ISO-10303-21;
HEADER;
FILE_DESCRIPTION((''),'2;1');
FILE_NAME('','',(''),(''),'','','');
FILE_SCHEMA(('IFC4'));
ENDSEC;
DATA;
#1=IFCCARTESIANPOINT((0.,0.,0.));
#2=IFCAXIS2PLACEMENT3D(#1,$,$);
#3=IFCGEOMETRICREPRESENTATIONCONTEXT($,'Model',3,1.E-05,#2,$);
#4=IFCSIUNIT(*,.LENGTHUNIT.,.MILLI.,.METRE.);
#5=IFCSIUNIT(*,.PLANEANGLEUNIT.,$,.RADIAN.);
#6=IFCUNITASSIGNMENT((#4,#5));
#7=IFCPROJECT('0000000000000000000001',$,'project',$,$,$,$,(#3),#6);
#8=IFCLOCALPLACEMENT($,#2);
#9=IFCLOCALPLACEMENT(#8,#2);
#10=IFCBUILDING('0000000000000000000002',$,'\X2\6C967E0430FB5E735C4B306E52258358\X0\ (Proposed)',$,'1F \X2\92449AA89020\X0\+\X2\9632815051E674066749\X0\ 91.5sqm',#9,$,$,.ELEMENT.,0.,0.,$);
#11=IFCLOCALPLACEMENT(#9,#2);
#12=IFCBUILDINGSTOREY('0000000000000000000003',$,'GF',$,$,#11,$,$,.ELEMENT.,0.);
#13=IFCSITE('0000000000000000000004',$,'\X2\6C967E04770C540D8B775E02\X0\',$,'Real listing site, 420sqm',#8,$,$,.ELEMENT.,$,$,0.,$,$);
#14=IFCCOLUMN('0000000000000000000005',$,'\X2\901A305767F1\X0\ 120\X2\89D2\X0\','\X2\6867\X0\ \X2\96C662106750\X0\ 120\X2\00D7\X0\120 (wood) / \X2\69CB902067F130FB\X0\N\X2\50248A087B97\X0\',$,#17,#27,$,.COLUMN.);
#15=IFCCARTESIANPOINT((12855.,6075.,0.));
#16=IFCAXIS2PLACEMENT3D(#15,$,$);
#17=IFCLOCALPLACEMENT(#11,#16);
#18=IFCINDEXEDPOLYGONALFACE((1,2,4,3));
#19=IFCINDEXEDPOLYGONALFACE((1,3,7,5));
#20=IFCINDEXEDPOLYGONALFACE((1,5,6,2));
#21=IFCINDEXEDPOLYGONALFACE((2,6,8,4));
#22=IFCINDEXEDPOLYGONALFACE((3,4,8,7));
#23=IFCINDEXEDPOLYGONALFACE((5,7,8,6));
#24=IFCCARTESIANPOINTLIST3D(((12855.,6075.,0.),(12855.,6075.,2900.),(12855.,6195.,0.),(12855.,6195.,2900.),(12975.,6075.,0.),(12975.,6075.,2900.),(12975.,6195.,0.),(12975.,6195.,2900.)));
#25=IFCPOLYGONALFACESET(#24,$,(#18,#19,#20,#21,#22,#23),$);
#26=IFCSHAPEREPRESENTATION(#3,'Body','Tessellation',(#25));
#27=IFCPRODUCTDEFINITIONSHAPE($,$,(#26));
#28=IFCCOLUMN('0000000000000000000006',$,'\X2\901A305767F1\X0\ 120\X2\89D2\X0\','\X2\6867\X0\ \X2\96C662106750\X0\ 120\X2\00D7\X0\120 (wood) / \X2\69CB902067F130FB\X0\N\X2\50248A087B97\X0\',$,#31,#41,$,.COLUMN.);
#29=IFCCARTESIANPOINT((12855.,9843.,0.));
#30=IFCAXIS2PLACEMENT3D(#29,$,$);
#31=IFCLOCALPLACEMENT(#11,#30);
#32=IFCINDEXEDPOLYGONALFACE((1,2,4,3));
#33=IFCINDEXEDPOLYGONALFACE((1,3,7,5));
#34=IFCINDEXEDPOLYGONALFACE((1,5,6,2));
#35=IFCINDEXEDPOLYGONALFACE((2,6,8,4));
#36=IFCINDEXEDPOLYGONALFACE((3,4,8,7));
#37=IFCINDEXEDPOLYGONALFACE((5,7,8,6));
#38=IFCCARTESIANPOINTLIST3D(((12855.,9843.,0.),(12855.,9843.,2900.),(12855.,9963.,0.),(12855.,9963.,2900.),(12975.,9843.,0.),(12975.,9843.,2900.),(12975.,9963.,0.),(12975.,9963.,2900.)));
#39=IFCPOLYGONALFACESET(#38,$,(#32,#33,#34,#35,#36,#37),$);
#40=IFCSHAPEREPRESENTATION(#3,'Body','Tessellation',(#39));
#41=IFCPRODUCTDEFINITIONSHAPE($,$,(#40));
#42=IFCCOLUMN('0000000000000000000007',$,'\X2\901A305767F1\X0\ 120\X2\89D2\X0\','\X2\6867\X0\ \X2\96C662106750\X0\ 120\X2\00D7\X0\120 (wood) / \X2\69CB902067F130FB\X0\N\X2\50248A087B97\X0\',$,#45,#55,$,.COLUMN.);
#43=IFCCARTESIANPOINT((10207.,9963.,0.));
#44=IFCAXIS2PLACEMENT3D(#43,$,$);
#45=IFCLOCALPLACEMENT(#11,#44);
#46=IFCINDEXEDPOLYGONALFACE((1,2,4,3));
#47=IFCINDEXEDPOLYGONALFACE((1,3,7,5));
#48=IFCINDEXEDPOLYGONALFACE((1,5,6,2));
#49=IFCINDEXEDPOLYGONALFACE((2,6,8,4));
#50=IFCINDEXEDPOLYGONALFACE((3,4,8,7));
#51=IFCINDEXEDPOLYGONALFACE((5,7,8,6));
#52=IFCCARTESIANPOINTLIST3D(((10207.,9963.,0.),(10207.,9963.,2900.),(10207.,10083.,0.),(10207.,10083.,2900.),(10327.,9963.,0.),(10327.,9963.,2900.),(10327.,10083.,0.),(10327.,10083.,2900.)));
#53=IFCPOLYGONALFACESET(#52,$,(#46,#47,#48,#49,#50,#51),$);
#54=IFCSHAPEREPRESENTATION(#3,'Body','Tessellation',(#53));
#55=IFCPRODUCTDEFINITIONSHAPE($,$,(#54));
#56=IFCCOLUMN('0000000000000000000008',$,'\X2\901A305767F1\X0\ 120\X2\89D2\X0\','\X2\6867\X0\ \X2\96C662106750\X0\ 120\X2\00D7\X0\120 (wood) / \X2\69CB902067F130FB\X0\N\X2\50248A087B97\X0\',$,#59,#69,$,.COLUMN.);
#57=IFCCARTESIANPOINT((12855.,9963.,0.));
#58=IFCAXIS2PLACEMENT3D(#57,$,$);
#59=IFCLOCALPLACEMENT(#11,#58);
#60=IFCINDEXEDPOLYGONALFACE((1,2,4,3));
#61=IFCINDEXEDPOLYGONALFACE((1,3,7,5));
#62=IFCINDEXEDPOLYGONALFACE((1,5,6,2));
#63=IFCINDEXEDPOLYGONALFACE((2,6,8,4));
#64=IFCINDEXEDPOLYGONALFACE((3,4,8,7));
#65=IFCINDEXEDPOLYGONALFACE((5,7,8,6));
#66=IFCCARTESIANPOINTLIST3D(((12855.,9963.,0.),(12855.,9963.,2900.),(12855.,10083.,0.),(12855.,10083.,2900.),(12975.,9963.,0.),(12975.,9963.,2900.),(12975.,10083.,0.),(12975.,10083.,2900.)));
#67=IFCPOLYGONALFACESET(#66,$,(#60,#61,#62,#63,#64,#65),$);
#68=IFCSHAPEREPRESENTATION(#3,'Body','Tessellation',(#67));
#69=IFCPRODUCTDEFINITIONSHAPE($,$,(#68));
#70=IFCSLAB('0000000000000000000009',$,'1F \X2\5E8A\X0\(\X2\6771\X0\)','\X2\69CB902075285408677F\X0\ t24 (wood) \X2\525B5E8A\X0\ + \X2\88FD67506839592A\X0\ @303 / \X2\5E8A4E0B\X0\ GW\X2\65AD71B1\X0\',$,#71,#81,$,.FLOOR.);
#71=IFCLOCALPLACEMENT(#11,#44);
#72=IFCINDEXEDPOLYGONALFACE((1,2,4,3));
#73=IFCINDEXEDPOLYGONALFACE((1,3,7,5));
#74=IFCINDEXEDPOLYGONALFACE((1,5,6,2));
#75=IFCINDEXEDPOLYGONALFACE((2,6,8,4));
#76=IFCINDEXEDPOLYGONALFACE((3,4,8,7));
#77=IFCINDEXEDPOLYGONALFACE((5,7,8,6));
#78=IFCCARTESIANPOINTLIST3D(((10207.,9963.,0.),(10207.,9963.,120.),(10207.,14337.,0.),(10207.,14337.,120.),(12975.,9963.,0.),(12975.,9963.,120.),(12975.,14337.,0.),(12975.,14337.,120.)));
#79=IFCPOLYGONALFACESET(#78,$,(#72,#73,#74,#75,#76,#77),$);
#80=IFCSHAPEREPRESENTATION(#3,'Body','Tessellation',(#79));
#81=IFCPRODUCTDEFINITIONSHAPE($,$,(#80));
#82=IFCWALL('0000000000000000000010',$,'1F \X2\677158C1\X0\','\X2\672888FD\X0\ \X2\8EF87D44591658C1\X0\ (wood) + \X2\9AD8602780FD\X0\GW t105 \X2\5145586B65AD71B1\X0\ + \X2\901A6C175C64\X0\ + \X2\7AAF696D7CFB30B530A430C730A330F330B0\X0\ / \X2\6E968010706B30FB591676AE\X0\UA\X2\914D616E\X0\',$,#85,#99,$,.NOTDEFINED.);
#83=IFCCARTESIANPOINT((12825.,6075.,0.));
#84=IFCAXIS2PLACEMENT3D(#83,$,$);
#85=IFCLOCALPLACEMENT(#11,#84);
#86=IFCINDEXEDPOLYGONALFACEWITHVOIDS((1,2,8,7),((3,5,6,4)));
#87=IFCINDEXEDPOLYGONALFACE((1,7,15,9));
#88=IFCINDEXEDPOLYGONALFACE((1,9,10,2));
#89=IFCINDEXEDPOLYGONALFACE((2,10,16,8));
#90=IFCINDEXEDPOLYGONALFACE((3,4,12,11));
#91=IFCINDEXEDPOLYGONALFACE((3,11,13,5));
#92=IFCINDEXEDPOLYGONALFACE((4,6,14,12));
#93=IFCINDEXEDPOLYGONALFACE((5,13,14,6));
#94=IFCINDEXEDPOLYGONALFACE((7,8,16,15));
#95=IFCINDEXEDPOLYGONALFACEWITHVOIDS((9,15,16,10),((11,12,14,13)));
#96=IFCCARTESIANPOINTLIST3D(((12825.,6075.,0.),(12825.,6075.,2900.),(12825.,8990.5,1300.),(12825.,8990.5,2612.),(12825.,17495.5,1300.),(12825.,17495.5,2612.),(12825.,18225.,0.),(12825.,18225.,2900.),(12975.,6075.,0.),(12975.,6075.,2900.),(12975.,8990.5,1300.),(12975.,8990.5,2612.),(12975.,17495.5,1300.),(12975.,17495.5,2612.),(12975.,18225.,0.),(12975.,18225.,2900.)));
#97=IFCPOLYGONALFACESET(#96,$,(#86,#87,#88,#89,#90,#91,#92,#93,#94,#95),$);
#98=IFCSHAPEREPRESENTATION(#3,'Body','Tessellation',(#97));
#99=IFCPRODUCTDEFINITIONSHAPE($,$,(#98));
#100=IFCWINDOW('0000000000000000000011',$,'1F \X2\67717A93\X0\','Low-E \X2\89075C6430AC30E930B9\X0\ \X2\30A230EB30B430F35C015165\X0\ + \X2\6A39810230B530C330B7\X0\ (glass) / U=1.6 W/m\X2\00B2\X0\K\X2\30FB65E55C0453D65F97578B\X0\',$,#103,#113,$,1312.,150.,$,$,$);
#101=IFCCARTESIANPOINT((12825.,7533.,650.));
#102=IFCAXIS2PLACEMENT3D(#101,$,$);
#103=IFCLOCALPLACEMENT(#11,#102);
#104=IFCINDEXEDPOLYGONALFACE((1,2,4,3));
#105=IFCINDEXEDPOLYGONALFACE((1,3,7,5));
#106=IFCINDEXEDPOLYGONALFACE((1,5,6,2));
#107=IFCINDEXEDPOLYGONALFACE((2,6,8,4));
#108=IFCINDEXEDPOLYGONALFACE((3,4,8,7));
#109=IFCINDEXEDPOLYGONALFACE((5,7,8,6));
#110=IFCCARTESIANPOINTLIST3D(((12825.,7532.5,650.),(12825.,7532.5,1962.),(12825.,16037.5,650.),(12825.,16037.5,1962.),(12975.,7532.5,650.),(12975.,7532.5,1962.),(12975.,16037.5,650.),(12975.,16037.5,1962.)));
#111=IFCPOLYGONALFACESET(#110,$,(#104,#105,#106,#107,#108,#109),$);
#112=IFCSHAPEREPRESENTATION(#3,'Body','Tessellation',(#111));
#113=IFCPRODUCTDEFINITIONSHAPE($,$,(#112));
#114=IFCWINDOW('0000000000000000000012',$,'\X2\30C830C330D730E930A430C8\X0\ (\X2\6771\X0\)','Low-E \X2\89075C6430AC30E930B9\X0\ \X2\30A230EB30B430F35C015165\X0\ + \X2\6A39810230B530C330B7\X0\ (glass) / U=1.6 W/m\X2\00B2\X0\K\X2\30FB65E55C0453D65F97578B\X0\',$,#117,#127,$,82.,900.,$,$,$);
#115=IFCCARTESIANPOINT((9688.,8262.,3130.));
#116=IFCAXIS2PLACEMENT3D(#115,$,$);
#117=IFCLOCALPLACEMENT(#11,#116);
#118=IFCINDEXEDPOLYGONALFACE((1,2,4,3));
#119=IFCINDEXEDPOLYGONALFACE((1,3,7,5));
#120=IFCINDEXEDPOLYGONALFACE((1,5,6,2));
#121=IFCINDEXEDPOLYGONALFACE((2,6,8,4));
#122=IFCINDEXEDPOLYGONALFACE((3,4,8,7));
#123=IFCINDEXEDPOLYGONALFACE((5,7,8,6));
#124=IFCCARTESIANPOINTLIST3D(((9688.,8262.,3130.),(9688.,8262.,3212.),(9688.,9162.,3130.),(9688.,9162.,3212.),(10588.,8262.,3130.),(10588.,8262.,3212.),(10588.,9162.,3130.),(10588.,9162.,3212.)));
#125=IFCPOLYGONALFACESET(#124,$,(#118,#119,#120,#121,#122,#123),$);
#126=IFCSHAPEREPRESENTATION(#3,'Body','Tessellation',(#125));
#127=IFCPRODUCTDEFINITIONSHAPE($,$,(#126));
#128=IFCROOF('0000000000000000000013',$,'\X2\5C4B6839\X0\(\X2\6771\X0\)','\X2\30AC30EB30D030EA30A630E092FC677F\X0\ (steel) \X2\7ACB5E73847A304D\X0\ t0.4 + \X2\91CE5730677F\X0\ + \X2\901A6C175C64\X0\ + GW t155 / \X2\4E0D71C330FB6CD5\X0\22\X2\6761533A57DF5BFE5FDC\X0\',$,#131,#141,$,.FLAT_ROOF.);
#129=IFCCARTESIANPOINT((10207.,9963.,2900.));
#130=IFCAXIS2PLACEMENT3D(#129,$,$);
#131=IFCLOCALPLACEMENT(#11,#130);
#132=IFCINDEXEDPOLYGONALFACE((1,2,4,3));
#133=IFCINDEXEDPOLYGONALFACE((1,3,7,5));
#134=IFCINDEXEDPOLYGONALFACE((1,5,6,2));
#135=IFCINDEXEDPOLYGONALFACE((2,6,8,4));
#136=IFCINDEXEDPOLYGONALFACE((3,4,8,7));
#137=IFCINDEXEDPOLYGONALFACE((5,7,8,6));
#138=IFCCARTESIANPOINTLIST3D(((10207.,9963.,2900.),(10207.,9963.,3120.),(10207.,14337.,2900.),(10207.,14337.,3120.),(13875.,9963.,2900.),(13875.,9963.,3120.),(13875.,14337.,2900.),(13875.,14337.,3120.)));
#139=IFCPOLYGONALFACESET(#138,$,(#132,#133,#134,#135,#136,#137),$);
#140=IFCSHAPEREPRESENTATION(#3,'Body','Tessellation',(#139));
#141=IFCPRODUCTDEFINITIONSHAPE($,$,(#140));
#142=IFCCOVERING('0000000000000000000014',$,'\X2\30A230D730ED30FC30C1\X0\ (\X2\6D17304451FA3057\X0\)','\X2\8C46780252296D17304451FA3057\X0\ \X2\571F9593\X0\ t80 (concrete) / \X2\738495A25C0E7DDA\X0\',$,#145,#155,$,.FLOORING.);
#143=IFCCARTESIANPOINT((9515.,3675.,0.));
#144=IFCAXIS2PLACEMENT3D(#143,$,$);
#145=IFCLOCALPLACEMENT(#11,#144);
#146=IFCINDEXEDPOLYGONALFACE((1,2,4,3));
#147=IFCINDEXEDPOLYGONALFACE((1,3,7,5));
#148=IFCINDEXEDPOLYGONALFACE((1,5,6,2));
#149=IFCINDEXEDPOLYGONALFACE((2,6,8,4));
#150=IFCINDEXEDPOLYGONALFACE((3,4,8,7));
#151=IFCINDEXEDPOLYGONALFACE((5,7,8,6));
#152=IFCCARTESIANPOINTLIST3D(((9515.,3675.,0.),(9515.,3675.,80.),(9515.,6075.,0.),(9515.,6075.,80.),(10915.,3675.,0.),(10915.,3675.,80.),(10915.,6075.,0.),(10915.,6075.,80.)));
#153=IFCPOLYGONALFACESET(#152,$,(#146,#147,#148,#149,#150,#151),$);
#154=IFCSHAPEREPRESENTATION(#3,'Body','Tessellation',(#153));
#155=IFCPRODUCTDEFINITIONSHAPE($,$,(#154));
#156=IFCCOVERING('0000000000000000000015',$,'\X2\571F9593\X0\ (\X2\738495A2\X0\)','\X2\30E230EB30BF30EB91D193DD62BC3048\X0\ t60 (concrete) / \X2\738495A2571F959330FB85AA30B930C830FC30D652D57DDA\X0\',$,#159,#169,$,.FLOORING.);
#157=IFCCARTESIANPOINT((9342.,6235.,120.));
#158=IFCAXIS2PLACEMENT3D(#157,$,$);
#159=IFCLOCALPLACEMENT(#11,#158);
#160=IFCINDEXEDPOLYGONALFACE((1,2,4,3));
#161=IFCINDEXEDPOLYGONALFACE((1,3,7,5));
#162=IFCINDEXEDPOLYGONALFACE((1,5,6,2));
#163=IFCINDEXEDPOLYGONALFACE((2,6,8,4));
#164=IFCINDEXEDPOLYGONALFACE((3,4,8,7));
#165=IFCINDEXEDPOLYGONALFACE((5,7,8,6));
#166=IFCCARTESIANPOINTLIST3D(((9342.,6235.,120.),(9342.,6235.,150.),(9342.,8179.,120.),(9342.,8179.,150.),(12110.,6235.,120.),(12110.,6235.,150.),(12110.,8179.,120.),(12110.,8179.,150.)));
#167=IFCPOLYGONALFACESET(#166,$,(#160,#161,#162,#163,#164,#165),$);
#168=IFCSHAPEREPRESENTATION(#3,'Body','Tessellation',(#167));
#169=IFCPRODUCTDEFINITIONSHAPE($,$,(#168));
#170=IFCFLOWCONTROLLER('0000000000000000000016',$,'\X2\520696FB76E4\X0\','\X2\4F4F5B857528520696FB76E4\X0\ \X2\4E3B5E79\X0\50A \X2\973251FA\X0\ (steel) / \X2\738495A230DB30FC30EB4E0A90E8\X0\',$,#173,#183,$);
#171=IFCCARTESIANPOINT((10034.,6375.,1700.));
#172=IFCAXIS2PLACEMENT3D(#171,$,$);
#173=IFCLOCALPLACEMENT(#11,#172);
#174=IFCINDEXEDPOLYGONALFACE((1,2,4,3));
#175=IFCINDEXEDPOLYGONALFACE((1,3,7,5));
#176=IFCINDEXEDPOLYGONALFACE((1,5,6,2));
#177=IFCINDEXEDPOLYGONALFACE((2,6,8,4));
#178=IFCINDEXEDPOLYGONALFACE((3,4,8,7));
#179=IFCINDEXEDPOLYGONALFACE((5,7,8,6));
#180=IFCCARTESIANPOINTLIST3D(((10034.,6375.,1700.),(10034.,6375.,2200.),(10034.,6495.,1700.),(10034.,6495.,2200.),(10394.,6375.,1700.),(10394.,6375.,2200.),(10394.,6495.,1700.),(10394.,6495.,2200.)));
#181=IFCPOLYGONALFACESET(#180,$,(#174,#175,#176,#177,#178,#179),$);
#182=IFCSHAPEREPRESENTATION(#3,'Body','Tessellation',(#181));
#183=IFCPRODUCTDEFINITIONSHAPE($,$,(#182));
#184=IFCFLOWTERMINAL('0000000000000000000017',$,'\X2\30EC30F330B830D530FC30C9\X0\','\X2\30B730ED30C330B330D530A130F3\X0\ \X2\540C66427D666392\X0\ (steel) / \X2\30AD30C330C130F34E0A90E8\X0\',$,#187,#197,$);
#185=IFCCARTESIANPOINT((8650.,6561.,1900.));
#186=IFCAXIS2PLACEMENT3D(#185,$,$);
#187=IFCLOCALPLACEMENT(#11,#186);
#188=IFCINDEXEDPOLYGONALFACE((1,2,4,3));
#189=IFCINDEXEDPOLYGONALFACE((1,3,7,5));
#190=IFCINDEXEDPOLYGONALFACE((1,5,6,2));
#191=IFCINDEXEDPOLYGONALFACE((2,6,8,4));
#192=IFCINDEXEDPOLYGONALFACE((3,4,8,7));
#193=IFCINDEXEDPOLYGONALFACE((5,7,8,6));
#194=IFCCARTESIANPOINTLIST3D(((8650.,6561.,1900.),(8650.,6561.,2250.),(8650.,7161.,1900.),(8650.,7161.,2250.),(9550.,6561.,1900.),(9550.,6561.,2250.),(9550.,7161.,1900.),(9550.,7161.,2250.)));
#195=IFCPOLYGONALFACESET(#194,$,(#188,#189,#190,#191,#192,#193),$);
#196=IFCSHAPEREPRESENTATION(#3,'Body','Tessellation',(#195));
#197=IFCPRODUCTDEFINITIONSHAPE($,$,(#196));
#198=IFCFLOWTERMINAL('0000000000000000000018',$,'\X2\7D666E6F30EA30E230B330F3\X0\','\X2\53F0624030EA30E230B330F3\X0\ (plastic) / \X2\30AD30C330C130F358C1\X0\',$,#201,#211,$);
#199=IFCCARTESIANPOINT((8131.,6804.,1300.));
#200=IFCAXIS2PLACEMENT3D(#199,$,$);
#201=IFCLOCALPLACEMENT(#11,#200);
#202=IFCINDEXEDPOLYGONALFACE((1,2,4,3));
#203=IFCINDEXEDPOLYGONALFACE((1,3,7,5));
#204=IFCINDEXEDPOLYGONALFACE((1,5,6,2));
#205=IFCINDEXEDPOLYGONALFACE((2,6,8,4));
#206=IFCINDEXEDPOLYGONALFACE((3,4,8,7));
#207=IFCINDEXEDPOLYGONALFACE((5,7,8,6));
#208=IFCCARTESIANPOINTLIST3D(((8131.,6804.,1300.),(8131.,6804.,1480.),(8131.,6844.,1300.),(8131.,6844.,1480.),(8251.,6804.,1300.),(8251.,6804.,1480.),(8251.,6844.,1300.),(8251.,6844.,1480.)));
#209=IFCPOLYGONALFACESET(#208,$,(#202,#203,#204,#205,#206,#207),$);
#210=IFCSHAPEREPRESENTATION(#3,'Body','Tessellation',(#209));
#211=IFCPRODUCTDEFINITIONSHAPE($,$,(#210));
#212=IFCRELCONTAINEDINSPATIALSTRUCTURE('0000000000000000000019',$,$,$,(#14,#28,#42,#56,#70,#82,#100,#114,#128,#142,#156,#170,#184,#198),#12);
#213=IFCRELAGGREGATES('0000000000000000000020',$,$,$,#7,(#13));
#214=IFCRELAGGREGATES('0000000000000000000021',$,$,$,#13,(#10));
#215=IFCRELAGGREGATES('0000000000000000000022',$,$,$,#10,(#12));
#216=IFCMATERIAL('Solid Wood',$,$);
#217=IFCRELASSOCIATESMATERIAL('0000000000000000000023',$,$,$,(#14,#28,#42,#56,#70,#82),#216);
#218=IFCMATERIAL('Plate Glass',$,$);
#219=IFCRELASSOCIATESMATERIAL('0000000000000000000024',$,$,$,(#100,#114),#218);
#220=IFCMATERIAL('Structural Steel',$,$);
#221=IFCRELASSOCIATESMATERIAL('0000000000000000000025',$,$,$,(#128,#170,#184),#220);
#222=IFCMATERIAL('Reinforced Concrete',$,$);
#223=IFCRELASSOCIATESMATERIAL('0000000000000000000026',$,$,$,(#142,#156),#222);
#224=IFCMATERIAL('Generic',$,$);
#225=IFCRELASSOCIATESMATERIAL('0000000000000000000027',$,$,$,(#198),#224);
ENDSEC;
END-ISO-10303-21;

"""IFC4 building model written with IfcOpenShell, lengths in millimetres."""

from ifc_helpers import new_model, si_unit, frame, frame_2d, origin, place, context, project, spatial, rectangle, extrude, material, element, fill, save


model = new_model("IFC4")

# Units and contexts
model_context = context("Model", 3, precision=1e-05, world=origin())
ifc_project = project(units=[si_unit("LENGTHUNIT", "METRE", prefix="MILLI"), si_unit("PLANEANGLEUNIT", "RADIAN")], contexts=[model_context])

# Site, building, storey
site_placement = place(None, origin())
site = spatial("IfcSite", under=ifc_project, at=site_placement, Name="沖縄県名護市", ObjectType="Real listing site, 420sqm", CompositionType="ELEMENT", RefElevation=0.0)
building_placement = place(site_placement, origin())
building = spatial("IfcBuilding", under=site, at=building_placement, Name="沖縄・平屋の別荘 (Proposed)", ObjectType="1F 鉄骨造+防腐処理杉 91.5sqm", CompositionType="ELEMENT", ElevationOfRefHeight=0.0, ElevationOfTerrain=0.0)
storey_placement = place(building_placement, origin())
storey = spatial("IfcBuildingStorey", under=building, at=storey_placement, Name="GF", CompositionType="ELEMENT", Elevation=0.0)

# Columns
ifc_material_1 = material(Name="Solid Wood")
column_1_placement = place(storey_placement, frame((12855.0, 6075.0, 0.0)))
element("IfcColumn", 1, at=column_1_placement, inside=storey, material=ifc_material_1, Name="通し柱 120角", Description="桧 集成材 120×120 (wood) / 構造柱・N値計算", PredefinedType="COLUMN", context=model_context, shape_type="SweptSolid", body=[
    extrude(rectangle(XDim=120.0, YDim=120.0, at=frame_2d((60.0, 60.0))), frame((12855.0, 6075.0, 0.0)), (0.0, 0.0, 1.0), 2900.0),
])
column_2_placement = place(storey_placement, frame((12855.0, 9843.0, 0.0)))
element("IfcColumn", 2, at=column_2_placement, inside=storey, material=ifc_material_1, Name="通し柱 120角", Description="桧 集成材 120×120 (wood) / 構造柱・N値計算", PredefinedType="COLUMN", context=model_context, shape_type="SweptSolid", body=[
    extrude(rectangle(XDim=120.0, YDim=120.0, at=frame_2d((60.0, 60.0))), frame((12855.0, 9843.0, 0.0)), (0.0, 0.0, 1.0), 2900.0),
])
column_3_placement = place(storey_placement, frame((10207.0, 9963.0, 0.0)))
element("IfcColumn", 3, at=column_3_placement, inside=storey, material=ifc_material_1, Name="通し柱 120角", Description="桧 集成材 120×120 (wood) / 構造柱・N値計算", PredefinedType="COLUMN", context=model_context, shape_type="SweptSolid", body=[
    extrude(rectangle(XDim=120.0, YDim=120.0, at=frame_2d((60.0, 60.0))), frame((10207.0, 9963.0, 0.0)), (0.0, 0.0, 1.0), 2900.0),
])
column_4_placement = place(storey_placement, frame((12855.0, 9963.0, 0.0)))
element("IfcColumn", 4, at=column_4_placement, inside=storey, material=ifc_material_1, Name="通し柱 120角", Description="桧 集成材 120×120 (wood) / 構造柱・N値計算", PredefinedType="COLUMN", context=model_context, shape_type="SweptSolid", body=[
    extrude(rectangle(XDim=120.0, YDim=120.0, at=frame_2d((60.0, 60.0))), frame((12855.0, 9963.0, 0.0)), (0.0, 0.0, 1.0), 2900.0),
])

# Slab
slab_placement = place(storey_placement, frame((10207.0, 9963.0, 0.0)))
element("IfcSlab", 5, at=slab_placement, inside=storey, material=ifc_material_1, Name="1F 床(東)", Description="構造用合板 t24 (wood) 剛床 + 製材根太 @303 / 床下 GW断熱", PredefinedType="FLOOR", context=model_context, shape_type="SweptSolid", body=[
    extrude(rectangle(XDim=2768.0, YDim=4374.0, at=frame_2d((1384.0, 2187.0))), frame((10207.0, 9963.0, 0.0)), (0.0, 0.0, 1.0), 120.0),
])

# Wall, opening, window
wall_1_placement = place(storey_placement, frame((12825.0, 6075.0, 0.0)))
wall_1 = element("IfcWall", 6, at=wall_1_placement, inside=storey, material=ifc_material_1, Name="1F 東壁", Description="木製 軸組外壁 (wood) + 高性能GW t105 充填断熱 + 通気層 + 窯業系サイディング / 準耐火・外皮UA配慮", PredefinedType="NOTDEFINED", context=model_context, shape_type="SweptSolid", body=[
    extrude(rectangle(XDim=150.0, YDim=12150.0, at=frame_2d((75.0, 6075.0))), frame((12825.0, 6075.0, 0.0)), (0.0, 0.0, 1.0), 2900.0),
])
opening_placement = place(storey_placement, frame((12825.0, 7533.0, 650.0)))
opening = element("IfcOpeningElement", 7, at=opening_placement, cuts=wall_1, PredefinedType="NOTDEFINED", context=model_context, shape_type="SweptSolid", body=[
    extrude(rectangle(XDim=150.0, YDim=8505.0, at=frame_2d((75.0, 4252.0))), frame((12825.0, 7533.0, 650.0)), (0.0, 0.0, 1.0), 1312.0),
])
ifc_material_2 = material(Name="Plate Glass")
window_1_placement = place(storey_placement, frame((12825.0, 7533.0, 650.0)))
window_1 = element("IfcWindow", 8, at=window_1_placement, inside=storey, material=ifc_material_2, Name="1F 東窓", Description="Low-E 複層ガラス アルゴン封入 + 樹脂サッシ (glass) / U=1.6 W/m²K・日射取得型", OverallHeight=1312.0, OverallWidth=150.0, context=model_context, shape_type="SweptSolid", body=[
    extrude(rectangle(XDim=150.0, YDim=8505.0, at=frame_2d((75.0, 4252.0))), frame((12825.0, 7533.0, 650.0)), (0.0, 0.0, 1.0), 1312.0),
])
fill(opening, window_1)

# Window
window_2_placement = place(storey_placement, frame((9688.0, 8262.0, 3130.0)))
element("IfcWindow", 9, at=window_2_placement, inside=storey, material=ifc_material_2, Name="トップライト (東)", Description="Low-E 複層ガラス アルゴン封入 + 樹脂サッシ (glass) / U=1.6 W/m²K・日射取得型", OverallHeight=82.0, OverallWidth=900.0, context=model_context, shape_type="SweptSolid", body=[
    extrude(rectangle(XDim=900.0, YDim=900.0, at=frame_2d((450.0, 450.0))), frame((9688.0, 8262.0, 3130.0)), (0.0, 0.0, 1.0), 82.0),
])

# Roof
ifc_material_3 = material(Name="Structural Steel")
roof_placement = place(storey_placement, frame((10207.0, 9963.0, 2900.0)))
element("IfcRoof", 10, at=roof_placement, inside=storey, material=ifc_material_3, Name="屋根(東)", Description="ガルバリウム鋼板 (steel) 立平葺き t0.4 + 野地板 + 通気層 + GW t155 / 不燃・法22条区域対応", PredefinedType="FLAT_ROOF", context=model_context, shape_type="SweptSolid", body=[
    extrude(rectangle(XDim=3668.0, YDim=4374.0, at=frame_2d((1834.0, 2187.0))), frame((10207.0, 9963.0, 2900.0)), (0.0, 0.0, 1.0), 220.0),
])

# Coverings
ifc_material_4 = material(Name="Reinforced Concrete")
covering_1_placement = place(storey_placement, frame((9515.0, 3675.0, 0.0)))
element("IfcCovering", 11, at=covering_1_placement, inside=storey, material=ifc_material_4, Name="アプローチ (洗い出し)", Description="豆砂利洗い出し 土間 t80 (concrete) / 玄関導線", PredefinedType="FLOORING", context=model_context, shape_type="SweptSolid", body=[
    extrude(rectangle(XDim=1400.0, YDim=2400.0, at=frame_2d((700.0, 1200.0))), frame((9515.0, 3675.0, 0.0)), (0.0, 0.0, 1.0), 80.0),
])
covering_2_placement = place(storey_placement, frame((9342.0, 6235.0, 120.0)))
element("IfcCovering", 12, at=covering_2_placement, inside=storey, material=ifc_material_4, Name="土間 (玄関)", Description="モルタル金鏝押え t60 (concrete) / 玄関土間・薪ストーブ動線", PredefinedType="FLOORING", context=model_context, shape_type="SweptSolid", body=[
    extrude(rectangle(XDim=2768.0, YDim=1944.0, at=frame_2d((1384.0, 972.0))), frame((9342.0, 6235.0, 120.0)), (0.0, 0.0, 1.0), 30.0),
])

# Flow controller
flow_controller_placement = place(storey_placement, frame((10034.0, 6375.0, 1700.0)))
element("IfcFlowController", 13, at=flow_controller_placement, inside=storey, material=ifc_material_3, Name="分電盤", Description="住宅用分電盤 主幹50A 露出 (steel) / 玄関ホール上部", context=model_context, shape_type="SweptSolid", body=[
    extrude(rectangle(XDim=360.0, YDim=120.0, at=frame_2d((180.0, 60.0))), frame((10034.0, 6375.0, 1700.0)), (0.0, 0.0, 1.0), 500.0),
])

# Flow terminals
flow_terminal_1_placement = place(storey_placement, frame((8650.0, 6561.0, 1900.0)))
element("IfcFlowTerminal", 14, at=flow_terminal_1_placement, inside=storey, material=ifc_material_3, Name="レンジフード", Description="シロッコファン 同時給排 (steel) / キッチン上部", context=model_context, shape_type="SweptSolid", body=[
    extrude(rectangle(XDim=900.0, YDim=600.0, at=frame_2d((450.0, 300.0))), frame((8650.0, 6561.0, 1900.0)), (0.0, 0.0, 1.0), 350.0),
])
ifc_material_5 = material(Name="Generic")
flow_terminal_2_placement = place(storey_placement, frame((8131.0, 6804.0, 1300.0)))
element("IfcFlowTerminal", 15, at=flow_terminal_2_placement, inside=storey, material=ifc_material_5, Name="給湯リモコン", Description="台所リモコン (plastic) / キッチン壁", context=model_context, shape_type="SweptSolid", body=[
    extrude(rectangle(XDim=120.0, YDim=40.0, at=frame_2d((60.0, 20.0))), frame((8131.0, 6804.0, 1300.0)), (0.0, 0.0, 1.0), 180.0),
])

save(model, "model.ifc")
